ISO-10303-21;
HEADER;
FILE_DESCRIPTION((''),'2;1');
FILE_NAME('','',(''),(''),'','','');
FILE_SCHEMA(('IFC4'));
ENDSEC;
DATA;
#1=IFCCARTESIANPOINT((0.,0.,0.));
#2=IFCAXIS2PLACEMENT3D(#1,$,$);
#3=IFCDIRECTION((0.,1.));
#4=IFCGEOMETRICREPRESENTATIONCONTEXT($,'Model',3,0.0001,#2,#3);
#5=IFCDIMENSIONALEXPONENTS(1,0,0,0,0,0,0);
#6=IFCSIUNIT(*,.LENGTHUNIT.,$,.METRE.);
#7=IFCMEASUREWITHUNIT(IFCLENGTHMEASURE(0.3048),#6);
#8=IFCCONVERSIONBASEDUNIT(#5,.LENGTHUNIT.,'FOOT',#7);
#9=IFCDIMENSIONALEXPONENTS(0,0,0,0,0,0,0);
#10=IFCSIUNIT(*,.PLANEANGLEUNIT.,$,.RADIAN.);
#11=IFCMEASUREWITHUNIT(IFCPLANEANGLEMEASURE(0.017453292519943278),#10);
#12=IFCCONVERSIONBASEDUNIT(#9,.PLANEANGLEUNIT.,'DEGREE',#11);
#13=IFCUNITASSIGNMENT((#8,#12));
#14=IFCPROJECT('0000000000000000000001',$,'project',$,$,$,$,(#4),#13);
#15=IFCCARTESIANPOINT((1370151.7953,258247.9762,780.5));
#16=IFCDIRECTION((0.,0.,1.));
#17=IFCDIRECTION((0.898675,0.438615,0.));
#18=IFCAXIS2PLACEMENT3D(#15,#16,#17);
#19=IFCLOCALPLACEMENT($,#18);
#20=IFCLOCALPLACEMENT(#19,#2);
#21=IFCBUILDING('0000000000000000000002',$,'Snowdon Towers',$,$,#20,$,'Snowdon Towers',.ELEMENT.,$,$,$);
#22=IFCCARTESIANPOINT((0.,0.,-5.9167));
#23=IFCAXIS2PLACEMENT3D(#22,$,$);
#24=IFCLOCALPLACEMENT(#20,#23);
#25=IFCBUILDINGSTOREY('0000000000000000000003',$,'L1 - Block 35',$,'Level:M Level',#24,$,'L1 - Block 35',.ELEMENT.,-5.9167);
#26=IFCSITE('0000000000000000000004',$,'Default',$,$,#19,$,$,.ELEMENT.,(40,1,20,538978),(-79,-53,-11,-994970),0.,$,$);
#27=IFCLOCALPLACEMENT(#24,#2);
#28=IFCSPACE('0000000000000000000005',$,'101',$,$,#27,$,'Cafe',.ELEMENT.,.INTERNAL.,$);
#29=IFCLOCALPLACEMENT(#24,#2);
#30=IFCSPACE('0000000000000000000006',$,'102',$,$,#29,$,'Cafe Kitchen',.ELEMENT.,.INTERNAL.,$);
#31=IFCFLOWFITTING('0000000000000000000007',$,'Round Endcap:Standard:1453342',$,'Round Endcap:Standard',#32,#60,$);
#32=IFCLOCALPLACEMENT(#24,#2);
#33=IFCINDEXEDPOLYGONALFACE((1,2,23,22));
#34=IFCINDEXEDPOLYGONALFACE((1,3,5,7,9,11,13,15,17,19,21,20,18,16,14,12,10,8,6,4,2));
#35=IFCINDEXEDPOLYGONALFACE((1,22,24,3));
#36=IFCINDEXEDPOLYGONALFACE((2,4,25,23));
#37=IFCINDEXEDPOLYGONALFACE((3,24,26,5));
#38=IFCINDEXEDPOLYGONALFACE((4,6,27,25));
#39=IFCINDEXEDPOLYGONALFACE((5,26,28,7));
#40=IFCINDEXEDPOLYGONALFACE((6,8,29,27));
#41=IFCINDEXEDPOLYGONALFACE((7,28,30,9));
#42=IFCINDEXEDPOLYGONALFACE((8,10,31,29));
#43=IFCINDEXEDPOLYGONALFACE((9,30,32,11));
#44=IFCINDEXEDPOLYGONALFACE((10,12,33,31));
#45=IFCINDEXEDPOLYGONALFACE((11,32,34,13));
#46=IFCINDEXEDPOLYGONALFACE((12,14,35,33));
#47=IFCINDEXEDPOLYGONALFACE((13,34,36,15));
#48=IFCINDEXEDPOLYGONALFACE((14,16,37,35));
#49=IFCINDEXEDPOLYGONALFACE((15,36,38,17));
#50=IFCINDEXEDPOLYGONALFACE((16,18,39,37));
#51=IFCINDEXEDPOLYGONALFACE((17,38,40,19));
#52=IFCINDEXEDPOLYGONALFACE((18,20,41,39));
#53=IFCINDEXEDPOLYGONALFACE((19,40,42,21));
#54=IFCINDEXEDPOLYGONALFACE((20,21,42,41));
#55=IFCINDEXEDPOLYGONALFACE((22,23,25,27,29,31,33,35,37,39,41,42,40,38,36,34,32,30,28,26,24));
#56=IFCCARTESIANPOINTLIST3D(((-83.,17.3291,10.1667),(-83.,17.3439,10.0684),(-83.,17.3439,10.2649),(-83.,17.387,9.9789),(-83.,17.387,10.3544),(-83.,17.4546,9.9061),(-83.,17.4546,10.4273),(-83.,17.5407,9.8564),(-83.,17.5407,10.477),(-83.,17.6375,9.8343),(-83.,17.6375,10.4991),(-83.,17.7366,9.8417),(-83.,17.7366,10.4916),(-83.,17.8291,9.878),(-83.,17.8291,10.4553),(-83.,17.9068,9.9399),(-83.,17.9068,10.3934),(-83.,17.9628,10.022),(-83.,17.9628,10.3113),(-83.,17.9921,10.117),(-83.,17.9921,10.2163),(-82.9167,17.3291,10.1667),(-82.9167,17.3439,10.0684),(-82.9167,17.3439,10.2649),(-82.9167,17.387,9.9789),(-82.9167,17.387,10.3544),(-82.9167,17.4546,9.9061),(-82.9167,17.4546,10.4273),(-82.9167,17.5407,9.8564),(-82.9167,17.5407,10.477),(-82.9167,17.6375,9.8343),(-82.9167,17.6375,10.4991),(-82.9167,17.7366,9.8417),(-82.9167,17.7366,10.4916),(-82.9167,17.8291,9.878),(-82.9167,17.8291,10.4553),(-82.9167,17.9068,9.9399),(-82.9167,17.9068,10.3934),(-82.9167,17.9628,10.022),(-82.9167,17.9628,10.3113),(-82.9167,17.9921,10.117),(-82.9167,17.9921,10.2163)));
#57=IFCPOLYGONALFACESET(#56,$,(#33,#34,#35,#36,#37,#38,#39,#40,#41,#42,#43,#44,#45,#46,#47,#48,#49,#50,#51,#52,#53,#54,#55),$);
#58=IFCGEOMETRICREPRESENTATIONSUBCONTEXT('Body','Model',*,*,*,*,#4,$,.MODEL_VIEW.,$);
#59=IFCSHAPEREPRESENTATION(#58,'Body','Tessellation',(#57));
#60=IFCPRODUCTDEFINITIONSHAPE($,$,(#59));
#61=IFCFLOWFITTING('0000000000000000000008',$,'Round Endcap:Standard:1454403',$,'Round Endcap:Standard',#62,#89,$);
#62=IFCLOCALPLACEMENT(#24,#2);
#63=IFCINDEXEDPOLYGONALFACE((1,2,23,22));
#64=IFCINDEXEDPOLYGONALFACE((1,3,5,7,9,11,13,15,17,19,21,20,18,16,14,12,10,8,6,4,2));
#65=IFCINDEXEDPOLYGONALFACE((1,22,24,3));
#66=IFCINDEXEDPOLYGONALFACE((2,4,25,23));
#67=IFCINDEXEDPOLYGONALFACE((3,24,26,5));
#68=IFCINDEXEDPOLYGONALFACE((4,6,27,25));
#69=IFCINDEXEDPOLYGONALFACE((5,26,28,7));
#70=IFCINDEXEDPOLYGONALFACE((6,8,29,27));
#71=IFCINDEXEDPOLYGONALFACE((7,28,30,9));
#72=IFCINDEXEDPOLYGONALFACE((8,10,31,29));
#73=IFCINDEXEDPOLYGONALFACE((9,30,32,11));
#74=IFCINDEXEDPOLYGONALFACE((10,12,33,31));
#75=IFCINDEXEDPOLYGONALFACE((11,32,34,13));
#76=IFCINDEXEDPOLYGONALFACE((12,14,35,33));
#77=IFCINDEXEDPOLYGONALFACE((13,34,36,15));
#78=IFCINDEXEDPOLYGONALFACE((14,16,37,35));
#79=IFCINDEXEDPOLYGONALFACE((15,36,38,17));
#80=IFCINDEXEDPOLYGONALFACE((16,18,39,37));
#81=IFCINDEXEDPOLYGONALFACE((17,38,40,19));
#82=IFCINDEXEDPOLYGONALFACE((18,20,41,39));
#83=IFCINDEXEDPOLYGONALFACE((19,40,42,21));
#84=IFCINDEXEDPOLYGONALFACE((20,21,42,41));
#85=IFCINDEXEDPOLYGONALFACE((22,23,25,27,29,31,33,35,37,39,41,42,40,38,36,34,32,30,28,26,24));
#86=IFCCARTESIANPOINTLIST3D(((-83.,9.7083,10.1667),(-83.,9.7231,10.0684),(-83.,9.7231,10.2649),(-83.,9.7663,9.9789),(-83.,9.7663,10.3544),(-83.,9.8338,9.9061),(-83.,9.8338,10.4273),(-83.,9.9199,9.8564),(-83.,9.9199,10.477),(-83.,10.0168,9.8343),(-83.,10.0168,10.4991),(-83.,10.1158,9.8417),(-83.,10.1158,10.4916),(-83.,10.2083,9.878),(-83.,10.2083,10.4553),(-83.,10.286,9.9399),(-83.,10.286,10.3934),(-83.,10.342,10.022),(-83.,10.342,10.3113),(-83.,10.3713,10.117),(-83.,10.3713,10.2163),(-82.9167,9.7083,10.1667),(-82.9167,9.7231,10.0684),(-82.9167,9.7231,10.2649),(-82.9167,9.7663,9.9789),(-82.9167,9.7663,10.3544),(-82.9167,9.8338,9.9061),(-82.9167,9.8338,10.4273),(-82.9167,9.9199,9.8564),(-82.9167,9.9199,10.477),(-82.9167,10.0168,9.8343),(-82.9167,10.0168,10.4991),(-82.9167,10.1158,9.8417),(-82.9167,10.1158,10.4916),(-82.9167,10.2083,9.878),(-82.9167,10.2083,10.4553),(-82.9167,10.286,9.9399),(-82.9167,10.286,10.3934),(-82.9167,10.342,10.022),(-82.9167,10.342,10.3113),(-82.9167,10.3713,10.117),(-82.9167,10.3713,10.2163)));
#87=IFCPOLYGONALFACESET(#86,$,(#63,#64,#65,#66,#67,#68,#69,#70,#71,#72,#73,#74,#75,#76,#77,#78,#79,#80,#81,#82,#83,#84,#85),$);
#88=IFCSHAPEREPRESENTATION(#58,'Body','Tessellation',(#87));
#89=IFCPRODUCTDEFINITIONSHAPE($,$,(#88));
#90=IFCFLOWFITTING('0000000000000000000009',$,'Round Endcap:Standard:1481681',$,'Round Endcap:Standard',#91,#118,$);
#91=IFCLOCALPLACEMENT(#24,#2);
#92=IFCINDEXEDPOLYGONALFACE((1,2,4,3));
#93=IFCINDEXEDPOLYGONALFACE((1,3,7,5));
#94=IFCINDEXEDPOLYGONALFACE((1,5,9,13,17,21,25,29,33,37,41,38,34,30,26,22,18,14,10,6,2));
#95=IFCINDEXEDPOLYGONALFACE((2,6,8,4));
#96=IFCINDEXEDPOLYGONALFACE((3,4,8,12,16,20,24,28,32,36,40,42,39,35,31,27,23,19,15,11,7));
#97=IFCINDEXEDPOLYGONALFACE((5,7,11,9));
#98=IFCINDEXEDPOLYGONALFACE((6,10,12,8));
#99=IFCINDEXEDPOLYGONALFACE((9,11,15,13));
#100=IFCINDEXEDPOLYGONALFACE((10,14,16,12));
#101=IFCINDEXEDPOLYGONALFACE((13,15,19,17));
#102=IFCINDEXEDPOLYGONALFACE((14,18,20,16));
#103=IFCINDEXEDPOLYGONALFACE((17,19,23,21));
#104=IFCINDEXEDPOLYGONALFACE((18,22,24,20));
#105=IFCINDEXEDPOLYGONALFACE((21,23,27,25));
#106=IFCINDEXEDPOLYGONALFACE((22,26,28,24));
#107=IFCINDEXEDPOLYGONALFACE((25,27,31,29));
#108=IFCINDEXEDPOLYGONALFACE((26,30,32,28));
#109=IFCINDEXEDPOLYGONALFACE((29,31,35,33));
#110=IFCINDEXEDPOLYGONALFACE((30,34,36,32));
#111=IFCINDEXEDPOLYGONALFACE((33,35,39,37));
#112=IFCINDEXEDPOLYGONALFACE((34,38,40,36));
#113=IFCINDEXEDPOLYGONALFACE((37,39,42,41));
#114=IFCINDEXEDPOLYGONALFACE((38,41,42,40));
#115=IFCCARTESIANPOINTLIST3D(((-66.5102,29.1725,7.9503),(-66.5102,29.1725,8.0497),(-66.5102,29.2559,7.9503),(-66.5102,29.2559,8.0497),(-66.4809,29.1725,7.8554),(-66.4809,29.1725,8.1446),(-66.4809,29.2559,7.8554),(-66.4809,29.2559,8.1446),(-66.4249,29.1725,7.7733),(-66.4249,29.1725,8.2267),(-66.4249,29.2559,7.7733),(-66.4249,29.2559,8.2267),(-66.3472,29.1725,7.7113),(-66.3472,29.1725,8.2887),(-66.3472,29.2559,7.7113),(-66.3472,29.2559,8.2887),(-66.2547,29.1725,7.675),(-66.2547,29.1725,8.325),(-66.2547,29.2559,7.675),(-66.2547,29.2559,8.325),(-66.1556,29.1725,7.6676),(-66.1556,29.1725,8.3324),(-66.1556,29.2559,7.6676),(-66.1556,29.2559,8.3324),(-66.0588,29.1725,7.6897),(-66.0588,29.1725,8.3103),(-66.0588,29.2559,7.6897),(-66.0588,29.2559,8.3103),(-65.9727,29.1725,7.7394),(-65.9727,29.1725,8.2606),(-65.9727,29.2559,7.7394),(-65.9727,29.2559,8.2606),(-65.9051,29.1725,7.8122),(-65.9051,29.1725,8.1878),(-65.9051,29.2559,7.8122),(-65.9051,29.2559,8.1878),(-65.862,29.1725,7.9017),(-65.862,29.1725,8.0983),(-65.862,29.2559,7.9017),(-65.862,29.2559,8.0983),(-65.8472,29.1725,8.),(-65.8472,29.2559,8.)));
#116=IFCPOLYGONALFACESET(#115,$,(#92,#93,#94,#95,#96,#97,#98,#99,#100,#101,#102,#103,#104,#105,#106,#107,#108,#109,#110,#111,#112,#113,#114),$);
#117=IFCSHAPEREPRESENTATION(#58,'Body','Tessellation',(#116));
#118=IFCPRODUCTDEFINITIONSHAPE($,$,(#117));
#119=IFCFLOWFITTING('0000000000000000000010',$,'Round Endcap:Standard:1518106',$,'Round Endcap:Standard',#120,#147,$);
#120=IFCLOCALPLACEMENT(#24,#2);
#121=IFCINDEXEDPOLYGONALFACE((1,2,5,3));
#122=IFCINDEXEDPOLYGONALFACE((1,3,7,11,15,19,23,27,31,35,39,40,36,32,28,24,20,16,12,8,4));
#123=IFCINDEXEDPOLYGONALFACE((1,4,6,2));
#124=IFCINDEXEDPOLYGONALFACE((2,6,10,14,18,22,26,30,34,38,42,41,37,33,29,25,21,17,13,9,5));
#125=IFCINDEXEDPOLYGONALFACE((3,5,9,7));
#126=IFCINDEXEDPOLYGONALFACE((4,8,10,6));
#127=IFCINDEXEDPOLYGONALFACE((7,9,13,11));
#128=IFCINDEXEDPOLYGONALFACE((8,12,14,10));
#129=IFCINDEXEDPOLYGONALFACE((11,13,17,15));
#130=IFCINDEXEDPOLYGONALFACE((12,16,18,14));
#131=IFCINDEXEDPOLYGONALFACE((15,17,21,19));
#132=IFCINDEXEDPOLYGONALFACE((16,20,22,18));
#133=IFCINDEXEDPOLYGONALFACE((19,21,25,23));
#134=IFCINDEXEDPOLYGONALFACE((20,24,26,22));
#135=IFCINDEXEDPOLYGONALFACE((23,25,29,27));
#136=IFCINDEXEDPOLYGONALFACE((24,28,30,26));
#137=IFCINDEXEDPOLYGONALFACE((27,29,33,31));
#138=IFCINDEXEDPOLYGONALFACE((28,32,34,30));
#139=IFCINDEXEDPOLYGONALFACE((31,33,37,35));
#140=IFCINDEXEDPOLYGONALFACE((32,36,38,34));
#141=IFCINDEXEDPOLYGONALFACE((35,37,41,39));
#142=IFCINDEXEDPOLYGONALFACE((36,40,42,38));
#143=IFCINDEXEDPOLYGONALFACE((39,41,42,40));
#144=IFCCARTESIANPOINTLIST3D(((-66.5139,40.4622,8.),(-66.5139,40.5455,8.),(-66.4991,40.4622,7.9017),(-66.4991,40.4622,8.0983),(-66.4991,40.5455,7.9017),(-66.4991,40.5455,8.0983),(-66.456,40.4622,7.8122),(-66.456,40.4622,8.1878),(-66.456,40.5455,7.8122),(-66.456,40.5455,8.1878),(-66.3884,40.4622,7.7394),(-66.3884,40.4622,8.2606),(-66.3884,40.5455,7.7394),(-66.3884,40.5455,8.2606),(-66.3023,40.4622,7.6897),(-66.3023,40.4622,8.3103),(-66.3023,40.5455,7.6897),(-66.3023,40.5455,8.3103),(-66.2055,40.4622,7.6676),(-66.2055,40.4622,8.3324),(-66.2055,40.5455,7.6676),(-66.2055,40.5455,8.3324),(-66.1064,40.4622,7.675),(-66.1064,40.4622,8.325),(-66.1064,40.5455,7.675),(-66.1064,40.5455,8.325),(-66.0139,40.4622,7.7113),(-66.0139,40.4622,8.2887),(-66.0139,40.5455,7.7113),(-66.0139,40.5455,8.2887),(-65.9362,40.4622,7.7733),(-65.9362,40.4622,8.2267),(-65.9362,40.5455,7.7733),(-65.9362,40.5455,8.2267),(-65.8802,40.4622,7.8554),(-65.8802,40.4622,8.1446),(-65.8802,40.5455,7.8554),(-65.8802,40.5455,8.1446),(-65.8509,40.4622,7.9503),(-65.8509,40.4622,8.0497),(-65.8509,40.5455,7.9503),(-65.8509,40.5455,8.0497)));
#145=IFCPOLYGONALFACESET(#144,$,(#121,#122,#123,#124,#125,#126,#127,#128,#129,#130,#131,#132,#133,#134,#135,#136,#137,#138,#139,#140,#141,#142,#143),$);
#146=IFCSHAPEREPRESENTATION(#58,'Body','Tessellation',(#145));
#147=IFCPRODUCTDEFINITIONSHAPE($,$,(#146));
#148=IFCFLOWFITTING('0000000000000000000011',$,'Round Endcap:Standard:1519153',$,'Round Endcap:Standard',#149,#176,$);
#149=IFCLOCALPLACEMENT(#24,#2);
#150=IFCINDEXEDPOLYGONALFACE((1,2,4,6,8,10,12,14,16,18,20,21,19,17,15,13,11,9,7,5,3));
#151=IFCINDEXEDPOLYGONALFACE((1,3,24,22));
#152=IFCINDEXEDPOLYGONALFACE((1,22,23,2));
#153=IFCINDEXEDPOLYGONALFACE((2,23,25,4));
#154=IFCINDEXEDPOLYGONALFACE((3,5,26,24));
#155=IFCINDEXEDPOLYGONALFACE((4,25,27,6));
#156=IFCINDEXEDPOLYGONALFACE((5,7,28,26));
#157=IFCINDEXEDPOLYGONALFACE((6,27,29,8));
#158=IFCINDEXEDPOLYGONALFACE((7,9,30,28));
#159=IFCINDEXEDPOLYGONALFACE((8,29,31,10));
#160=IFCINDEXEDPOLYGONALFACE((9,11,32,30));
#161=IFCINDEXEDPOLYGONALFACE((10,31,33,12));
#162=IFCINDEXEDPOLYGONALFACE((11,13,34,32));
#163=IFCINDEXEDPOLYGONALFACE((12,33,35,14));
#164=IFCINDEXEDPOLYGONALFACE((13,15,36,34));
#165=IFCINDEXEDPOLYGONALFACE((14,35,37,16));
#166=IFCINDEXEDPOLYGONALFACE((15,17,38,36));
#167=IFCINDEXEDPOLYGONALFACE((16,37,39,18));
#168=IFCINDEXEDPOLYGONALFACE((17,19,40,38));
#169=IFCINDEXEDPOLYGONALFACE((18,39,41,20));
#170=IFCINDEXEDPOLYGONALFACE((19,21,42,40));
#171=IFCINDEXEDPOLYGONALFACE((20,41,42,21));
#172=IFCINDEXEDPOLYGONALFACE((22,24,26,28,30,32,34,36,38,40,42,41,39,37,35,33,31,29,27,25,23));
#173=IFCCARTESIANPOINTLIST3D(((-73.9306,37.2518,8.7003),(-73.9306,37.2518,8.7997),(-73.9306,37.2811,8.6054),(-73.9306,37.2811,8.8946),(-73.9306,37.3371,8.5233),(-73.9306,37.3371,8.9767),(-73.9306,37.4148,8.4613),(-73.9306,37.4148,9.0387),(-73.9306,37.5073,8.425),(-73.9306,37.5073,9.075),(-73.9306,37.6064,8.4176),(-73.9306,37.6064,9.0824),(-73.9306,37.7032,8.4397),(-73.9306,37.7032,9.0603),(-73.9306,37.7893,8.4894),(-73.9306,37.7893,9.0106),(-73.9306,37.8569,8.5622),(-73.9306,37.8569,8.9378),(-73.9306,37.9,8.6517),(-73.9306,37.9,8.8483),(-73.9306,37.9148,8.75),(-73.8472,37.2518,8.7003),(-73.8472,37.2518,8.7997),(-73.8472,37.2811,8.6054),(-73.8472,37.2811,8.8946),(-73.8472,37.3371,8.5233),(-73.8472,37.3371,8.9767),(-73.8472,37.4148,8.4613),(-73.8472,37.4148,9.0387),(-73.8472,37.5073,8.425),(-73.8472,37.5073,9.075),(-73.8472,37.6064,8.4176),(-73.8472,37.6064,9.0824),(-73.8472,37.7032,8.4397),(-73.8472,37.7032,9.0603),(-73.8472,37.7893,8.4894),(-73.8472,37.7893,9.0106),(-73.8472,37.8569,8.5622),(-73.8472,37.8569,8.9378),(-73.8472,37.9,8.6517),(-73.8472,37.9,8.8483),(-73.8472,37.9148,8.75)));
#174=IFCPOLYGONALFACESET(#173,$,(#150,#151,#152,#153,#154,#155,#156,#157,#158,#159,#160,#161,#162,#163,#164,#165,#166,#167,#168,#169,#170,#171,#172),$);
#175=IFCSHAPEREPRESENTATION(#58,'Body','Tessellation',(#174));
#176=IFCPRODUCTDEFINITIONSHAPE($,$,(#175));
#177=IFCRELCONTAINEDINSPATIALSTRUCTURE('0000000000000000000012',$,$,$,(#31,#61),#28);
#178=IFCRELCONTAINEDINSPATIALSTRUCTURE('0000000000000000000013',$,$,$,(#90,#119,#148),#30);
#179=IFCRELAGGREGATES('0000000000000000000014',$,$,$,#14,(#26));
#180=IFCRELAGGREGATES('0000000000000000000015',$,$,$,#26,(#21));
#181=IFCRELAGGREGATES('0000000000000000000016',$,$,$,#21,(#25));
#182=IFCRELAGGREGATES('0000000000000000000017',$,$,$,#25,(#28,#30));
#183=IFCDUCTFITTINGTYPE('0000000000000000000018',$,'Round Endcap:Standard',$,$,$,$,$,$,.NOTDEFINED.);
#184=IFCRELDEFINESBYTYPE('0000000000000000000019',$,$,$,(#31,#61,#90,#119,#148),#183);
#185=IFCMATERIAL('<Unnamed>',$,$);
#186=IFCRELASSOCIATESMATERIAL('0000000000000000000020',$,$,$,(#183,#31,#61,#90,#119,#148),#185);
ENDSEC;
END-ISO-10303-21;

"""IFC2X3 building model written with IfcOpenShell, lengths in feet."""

from ifc_helpers import new_model, entity, si_unit, converted_unit, direction, frame, frame_2d, origin, place, context, subcontext, project, spatial, circle, extrude, source, transform, mapped, material, type_object, type_shapes, element, save


model = new_model("IFC2X3")

# Units and contexts
model_context = context("Model", 3, precision=0.0001, world=origin(), true_north=direction((0.0, 1.0)))
body_context = subcontext(model_context, "Body", "Model", "MODEL_VIEW")
ifc_project = project(units=[converted_unit("LENGTHUNIT", "FOOT", entity("IfcLengthMeasure", 0.3048), si_unit("LENGTHUNIT", "METRE"), dimensions=[1, 0, 0, 0, 0, 0, 0]), converted_unit("PLANEANGLEUNIT", "DEGREE", entity("IfcPlaneAngleMeasure", 0.017453292519943278), si_unit("PLANEANGLEUNIT", "RADIAN"), dimensions=[0, 0, 0, 0, 0, 0, 0])], contexts=[model_context])

# Site, building, storey
site_placement = place(None, frame((1370151.7953, 258247.9762, 780.5), z_axis=(0.0, 0.0, 1.0), x_axis=(0.898675, 0.438615, 0.0)))
site = spatial("IfcSite", under=ifc_project, at=site_placement, Name="Default", CompositionType="ELEMENT", RefLatitude=(40, 1, 20, 538978), RefLongitude=(-79, -53, -11, -994970), RefElevation=0.0)
building_placement = place(site_placement, origin())
building = spatial("IfcBuilding", under=site, at=building_placement, Name="Snowdon Towers", LongName="Snowdon Towers", CompositionType="ELEMENT")
storey_placement = place(building_placement, frame((0.0, 0.0, -5.9167)))
storey = spatial("IfcBuildingStorey", under=building, at=storey_placement, Name="L1 - Block 35", ObjectType="Level:M Level", LongName="L1 - Block 35", CompositionType="ELEMENT", Elevation=-5.9167)

# Shared definitions
ifc_material = material(Name="<Unnamed>")

# Shared definitions
space_1_placement = place(storey_placement, origin())
space_1 = spatial("IfcSpace", under=storey, at=space_1_placement, Name="101", LongName="Cafe", CompositionType="ELEMENT", InteriorOrExteriorSpace="INTERNAL")

# Flow fittings
duct_fitting_type = type_object("IfcDuctFittingType", Name="Round Endcap:Standard", PredefinedType="NOTDEFINED", material=ifc_material)
shared_shape_1 = source(origin(), body_context, "Body", "SweptSolid", [
    extrude(circle(Radius=0.3333, at=frame_2d((0.0, 0.0), x_axis=(1.0, 0.0))), frame((0.0, 0.0, 0.0), z_axis=(1.0, 0.0, 0.0), x_axis=(0.0, 1.0, 0.0)), (0.0, 0.0, 1.0), 0.0833),
])
type_shapes(duct_fitting_type, [shared_shape_1])
for number, where, z_axis, x_axis, name in (
    (1, (-82.9167, 17.6624, 10.1667), (0.0, 0.0, 1.0), (-1.0, 0.0, 0.0), "Round Endcap:Standard:1453342"),
    (2, (-82.9167, 10.0417, 10.1667), (0.0, 0.0, 1.0), (-1.0, 0.0, 0.0), "Round Endcap:Standard:1454403"),
):
    element("IfcFlowFitting", number, at=place(space_1_placement, frame(where, z_axis=z_axis, x_axis=x_axis)), inside=space_1, type_object=duct_fitting_type, material=ifc_material, Name=name, ObjectType="Round Endcap:Standard", context=body_context, shape_type="MappedRepresentation", body=[
        mapped(shared_shape_1, transform((0.0, 0.0, 0.0), scale=1.0)),
    ])

# Shared definitions
space_2_placement = place(storey_placement, origin())
space_2 = spatial("IfcSpace", under=storey, at=space_2_placement, Name="102", LongName="Cafe Kitchen", CompositionType="ELEMENT", InteriorOrExteriorSpace="INTERNAL")

# Flow fittings
for number, where, z_axis, x_axis, name in (
    (3, (-66.1806, 29.2559, 8.0), (0.0, 0.0, 1.0), (0.0, -1.0, 0.0), "Round Endcap:Standard:1481681"),
    (4, (-66.1806, 40.4622, 8.0), (0.0, 0.0, 1.0), (0.0, 1.0, 0.0), "Round Endcap:Standard:1518106"),
):
    element("IfcFlowFitting", number, at=place(space_2_placement, frame(where, z_axis=z_axis, x_axis=x_axis)), inside=space_2, type_object=duct_fitting_type, material=ifc_material, Name=name, ObjectType="Round Endcap:Standard", context=body_context, shape_type="MappedRepresentation", body=[
        mapped(shared_shape_1, transform((0.0, 0.0, 0.0), scale=1.0)),
    ])
flow_fitting_placement = place(space_2_placement, frame((-73.9306, 37.5814, 8.75)))
element("IfcFlowFitting", 5, at=flow_fitting_placement, inside=space_2, type_object=duct_fitting_type, material=ifc_material, Name="Round Endcap:Standard:1519153", ObjectType="Round Endcap:Standard", context=body_context, shape_type="MappedRepresentation", body=[
    mapped(shared_shape_1, transform((0.0, 0.0, 0.0), scale=1.0)),
])

save(model, "model.ifc")
